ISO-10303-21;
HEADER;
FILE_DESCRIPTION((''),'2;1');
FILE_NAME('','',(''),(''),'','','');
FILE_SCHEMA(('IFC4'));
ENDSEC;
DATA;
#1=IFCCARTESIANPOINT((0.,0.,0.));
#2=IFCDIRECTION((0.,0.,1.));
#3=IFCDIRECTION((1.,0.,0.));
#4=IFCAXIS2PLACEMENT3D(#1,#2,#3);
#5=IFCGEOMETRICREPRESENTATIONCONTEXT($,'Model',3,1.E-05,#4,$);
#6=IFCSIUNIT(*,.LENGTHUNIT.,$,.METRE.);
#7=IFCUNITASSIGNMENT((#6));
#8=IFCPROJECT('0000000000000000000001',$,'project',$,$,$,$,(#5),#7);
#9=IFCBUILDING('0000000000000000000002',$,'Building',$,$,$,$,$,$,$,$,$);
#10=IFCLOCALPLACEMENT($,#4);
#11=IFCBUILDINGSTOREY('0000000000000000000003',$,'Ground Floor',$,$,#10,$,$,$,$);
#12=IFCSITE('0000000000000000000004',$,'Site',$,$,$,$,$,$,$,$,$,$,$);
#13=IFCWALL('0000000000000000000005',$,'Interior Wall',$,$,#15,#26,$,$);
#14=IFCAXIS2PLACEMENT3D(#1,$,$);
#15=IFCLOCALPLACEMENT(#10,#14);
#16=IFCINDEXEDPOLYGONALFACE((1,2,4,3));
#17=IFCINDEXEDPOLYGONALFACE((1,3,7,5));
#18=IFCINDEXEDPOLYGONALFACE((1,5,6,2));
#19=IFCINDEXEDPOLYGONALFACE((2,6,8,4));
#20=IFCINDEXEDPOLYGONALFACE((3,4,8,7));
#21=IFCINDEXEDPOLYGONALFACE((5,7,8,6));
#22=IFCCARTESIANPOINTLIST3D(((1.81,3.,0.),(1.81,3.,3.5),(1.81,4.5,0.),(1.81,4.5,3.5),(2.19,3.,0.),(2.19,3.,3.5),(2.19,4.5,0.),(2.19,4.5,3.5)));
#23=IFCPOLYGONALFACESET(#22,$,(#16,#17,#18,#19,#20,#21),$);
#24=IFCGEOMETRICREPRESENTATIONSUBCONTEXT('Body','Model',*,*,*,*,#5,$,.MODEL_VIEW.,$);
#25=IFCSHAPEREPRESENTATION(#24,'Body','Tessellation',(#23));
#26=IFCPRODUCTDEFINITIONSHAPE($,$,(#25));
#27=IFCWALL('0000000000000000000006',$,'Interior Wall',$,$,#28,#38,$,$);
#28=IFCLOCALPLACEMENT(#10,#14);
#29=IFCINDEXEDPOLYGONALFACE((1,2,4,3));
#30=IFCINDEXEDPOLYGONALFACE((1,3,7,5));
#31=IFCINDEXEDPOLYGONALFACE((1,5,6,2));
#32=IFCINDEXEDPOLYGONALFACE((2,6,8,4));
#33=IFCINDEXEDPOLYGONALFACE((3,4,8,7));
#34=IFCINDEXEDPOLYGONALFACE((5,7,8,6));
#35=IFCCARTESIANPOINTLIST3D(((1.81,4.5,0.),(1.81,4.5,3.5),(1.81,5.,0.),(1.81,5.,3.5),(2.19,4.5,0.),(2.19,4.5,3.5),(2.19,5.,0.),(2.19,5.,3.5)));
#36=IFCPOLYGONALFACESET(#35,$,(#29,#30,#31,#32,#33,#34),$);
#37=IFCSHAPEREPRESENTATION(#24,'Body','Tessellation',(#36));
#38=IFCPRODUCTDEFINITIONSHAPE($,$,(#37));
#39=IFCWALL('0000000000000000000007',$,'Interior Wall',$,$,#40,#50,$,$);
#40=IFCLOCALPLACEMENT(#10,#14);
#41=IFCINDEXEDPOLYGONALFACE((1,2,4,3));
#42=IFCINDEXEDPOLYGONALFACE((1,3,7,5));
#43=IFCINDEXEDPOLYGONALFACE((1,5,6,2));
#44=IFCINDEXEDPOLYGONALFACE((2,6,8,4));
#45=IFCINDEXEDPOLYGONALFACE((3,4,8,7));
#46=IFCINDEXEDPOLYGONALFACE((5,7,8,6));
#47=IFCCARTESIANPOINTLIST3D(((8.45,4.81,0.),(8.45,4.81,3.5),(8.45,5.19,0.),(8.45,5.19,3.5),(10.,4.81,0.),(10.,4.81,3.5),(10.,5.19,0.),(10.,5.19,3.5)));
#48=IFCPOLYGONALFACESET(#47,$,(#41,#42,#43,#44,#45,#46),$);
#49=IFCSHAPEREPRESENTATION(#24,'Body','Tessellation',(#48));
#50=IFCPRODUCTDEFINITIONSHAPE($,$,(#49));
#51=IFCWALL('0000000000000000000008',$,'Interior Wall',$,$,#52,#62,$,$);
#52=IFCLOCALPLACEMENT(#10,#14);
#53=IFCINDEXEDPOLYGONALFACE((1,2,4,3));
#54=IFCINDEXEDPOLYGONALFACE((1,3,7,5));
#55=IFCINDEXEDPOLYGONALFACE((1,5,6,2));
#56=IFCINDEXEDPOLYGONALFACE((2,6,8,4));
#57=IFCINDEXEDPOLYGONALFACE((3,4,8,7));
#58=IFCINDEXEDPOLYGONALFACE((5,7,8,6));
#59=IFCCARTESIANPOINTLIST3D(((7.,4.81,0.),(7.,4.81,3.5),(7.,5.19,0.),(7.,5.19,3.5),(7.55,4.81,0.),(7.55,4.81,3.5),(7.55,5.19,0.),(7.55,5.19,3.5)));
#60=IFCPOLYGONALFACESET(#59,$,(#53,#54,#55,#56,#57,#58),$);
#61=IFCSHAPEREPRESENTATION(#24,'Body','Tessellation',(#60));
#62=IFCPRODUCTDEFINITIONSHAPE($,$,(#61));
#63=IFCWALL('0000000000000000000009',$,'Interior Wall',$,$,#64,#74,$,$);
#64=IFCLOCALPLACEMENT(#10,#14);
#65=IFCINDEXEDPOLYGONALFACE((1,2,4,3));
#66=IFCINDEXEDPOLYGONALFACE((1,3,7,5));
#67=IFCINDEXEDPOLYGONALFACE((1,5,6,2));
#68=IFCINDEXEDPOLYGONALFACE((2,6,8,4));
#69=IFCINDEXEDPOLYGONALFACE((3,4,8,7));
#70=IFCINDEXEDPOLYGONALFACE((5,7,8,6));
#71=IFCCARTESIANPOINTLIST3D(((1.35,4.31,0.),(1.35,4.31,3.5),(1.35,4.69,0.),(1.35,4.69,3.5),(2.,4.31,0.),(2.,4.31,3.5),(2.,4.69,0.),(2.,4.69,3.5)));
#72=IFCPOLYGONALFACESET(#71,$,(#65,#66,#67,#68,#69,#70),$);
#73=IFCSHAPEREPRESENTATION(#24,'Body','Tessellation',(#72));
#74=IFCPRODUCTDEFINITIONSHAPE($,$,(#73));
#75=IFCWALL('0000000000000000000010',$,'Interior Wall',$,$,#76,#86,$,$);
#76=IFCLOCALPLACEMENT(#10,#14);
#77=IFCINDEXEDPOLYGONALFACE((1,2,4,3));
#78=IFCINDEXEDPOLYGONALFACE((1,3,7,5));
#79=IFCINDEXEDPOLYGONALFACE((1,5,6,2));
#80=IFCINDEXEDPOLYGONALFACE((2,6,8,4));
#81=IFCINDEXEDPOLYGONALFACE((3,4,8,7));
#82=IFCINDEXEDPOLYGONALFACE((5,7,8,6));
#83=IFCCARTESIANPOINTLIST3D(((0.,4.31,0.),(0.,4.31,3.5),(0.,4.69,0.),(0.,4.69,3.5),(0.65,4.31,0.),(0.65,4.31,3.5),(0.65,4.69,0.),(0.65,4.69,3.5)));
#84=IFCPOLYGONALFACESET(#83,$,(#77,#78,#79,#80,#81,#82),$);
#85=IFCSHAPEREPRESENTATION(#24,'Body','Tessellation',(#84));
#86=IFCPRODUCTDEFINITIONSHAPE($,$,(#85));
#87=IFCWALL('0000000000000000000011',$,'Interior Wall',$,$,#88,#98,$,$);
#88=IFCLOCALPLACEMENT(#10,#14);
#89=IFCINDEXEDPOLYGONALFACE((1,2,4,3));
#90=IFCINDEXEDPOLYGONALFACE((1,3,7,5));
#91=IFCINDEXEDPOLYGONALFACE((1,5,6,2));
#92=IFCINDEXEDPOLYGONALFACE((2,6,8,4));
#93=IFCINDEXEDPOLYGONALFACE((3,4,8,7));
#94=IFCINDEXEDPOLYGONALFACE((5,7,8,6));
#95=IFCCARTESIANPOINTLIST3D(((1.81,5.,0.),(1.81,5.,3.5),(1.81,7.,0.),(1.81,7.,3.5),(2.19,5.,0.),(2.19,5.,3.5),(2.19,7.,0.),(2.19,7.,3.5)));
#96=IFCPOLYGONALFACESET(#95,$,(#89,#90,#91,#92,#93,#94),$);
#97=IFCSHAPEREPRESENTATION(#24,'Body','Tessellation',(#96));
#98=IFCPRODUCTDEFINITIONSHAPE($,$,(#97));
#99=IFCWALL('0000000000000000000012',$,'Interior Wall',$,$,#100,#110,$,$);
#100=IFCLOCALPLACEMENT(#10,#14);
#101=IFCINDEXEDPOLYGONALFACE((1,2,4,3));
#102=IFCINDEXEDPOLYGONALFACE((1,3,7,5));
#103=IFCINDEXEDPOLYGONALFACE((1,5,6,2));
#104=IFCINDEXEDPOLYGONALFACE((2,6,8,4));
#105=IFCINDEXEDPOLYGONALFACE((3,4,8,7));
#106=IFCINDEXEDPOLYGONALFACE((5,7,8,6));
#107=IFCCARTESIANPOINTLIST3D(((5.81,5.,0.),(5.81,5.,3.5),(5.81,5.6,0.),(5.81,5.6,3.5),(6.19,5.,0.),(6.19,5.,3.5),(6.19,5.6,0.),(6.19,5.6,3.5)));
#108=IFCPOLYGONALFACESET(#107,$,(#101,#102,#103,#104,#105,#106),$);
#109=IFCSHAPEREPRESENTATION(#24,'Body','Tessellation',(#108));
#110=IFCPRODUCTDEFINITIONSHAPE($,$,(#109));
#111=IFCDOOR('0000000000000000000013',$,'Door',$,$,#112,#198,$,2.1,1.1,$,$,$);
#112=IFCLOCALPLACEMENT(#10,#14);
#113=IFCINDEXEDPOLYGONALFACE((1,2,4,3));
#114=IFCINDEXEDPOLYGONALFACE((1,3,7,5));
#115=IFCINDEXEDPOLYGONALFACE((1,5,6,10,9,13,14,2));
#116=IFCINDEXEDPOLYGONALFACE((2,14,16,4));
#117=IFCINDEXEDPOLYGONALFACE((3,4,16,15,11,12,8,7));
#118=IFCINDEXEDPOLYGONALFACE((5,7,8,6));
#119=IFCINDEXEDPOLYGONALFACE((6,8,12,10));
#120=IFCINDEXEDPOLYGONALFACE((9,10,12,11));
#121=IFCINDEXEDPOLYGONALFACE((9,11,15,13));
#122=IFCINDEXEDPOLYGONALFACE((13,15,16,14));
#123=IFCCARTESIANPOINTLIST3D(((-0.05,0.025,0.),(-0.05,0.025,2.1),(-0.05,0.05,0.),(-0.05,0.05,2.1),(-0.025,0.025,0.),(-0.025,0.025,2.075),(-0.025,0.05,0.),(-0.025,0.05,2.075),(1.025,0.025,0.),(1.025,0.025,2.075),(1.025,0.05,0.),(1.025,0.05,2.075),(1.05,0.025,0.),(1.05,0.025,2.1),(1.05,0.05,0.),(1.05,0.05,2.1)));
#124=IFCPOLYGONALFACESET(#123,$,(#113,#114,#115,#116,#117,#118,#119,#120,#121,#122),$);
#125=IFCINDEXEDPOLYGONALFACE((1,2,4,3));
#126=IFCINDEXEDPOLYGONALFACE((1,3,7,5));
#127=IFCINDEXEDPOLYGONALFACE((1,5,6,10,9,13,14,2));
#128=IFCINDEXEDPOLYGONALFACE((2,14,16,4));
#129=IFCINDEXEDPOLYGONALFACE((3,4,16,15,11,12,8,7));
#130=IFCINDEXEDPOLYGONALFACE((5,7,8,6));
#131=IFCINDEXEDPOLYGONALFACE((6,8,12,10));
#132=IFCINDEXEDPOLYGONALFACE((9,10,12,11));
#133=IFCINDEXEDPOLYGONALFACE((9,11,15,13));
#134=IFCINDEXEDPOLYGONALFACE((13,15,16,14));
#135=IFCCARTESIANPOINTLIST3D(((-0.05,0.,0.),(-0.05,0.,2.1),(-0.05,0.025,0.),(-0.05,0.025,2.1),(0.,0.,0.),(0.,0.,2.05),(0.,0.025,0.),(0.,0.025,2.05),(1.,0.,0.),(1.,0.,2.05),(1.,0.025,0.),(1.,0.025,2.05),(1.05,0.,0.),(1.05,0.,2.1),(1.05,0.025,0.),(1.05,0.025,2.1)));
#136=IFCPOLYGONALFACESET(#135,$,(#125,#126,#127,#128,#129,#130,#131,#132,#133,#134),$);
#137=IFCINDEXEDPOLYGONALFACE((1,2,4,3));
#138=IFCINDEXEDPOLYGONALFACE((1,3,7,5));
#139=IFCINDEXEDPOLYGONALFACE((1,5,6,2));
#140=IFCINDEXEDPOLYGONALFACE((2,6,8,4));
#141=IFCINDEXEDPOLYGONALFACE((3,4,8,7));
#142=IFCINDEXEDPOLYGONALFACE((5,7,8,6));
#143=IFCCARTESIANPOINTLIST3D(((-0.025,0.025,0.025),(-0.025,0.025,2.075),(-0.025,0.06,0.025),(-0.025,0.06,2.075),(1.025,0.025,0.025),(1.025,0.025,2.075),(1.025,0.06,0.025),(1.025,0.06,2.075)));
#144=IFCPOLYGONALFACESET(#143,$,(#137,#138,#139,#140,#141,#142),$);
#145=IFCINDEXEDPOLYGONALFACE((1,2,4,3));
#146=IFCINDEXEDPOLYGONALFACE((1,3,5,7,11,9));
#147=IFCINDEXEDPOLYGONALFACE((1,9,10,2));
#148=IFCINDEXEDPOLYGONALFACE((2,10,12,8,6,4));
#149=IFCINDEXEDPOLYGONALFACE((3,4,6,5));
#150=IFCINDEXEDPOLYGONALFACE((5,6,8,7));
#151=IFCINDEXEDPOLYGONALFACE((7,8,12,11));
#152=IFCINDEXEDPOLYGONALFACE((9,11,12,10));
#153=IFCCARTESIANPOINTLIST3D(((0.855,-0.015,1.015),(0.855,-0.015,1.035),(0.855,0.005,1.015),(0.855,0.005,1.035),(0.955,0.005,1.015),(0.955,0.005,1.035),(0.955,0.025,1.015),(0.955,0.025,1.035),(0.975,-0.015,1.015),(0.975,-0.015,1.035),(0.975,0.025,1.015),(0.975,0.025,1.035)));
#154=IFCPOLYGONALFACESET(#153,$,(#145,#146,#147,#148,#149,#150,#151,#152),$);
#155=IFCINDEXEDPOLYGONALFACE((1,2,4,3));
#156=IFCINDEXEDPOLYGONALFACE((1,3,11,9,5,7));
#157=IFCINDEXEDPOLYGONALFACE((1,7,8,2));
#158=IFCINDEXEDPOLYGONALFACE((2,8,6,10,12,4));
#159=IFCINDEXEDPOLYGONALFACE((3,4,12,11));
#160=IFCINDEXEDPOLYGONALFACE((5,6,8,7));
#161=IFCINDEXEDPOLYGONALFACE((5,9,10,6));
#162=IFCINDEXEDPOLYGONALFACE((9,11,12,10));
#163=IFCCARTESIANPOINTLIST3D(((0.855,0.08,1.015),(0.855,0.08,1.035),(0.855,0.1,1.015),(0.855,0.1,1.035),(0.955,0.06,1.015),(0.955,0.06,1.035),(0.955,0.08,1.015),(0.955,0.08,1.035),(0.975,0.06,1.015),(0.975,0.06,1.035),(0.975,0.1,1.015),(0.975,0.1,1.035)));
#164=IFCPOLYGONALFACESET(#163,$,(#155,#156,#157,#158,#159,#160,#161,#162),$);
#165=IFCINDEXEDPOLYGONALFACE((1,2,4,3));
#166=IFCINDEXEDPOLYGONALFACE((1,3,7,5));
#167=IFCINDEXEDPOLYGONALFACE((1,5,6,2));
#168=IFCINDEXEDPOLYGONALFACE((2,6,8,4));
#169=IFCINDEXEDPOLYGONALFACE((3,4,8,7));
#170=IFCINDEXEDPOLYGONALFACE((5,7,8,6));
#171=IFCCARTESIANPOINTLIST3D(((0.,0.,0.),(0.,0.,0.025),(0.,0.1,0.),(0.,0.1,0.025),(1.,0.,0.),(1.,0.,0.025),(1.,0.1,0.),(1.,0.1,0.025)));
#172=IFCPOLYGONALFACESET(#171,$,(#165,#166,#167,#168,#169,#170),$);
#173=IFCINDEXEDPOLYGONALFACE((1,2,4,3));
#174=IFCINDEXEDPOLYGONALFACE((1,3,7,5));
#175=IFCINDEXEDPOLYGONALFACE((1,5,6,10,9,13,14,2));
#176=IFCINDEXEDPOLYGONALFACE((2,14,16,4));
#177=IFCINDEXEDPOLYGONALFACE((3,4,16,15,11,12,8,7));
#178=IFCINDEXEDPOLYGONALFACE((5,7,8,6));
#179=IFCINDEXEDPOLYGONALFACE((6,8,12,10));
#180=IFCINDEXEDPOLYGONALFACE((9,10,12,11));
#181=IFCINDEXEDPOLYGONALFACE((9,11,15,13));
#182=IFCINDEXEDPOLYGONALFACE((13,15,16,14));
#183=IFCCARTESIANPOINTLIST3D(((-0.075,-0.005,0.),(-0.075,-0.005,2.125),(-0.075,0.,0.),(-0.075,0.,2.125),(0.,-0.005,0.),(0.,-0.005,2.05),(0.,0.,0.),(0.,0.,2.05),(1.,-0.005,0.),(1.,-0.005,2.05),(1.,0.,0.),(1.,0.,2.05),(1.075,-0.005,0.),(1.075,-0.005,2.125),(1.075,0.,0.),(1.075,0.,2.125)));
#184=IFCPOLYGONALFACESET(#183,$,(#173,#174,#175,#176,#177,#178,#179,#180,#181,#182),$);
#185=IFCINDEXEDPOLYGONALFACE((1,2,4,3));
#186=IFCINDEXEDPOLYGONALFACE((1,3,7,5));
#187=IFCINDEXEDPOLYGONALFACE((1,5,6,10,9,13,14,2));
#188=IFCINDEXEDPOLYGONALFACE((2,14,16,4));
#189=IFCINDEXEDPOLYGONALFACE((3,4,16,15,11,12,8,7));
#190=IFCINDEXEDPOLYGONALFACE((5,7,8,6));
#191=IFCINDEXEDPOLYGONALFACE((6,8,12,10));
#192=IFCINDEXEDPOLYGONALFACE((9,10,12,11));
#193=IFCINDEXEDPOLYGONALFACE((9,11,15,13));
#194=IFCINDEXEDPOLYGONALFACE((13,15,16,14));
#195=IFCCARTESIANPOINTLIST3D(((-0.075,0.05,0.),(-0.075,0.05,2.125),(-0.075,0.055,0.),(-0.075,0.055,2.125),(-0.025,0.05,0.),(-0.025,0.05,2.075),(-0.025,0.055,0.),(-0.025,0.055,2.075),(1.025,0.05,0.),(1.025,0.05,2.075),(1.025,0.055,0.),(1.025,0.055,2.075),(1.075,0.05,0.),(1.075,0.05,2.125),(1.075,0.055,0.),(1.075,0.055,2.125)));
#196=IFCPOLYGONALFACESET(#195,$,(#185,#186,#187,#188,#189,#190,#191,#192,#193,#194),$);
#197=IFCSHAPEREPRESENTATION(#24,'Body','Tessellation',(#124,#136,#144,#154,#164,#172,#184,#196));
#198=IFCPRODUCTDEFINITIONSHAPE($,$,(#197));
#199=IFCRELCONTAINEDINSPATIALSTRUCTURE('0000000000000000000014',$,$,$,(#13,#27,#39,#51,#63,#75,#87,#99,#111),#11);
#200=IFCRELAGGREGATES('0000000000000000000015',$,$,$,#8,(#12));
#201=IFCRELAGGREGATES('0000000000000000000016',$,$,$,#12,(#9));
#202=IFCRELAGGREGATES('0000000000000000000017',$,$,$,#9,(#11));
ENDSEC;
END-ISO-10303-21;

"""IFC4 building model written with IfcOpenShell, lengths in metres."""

from ifc_helpers import new_model, si_unit, frame, origin_with_axes, place, context, subcontext, project, spatial, line, indexed_curve, outline, extrude, element, save


model = new_model("IFC4")

# Units and contexts
model_context = context("Model", 3, precision=1e-05, world=origin_with_axes())
body_context = subcontext(model_context, "Body", "Model", "MODEL_VIEW")
ifc_project = project(units=[si_unit("LENGTHUNIT", "METRE")], contexts=[model_context])

# Site, building, storey
site = spatial("IfcSite", under=ifc_project, Name="Site")
building = spatial("IfcBuilding", under=site, Name="Building")
storey_placement = place(None, origin_with_axes())
storey = spatial("IfcBuildingStorey", under=building, at=storey_placement, Name="Ground Floor")

# Walls
wall_1_placement = place(storey_placement, frame((2.0, 4.5, 0.0), z_axis=(0.0, 0.0, 1.0), x_axis=(0.0, -1.0, 0.0)))
element("IfcWall", 1, at=wall_1_placement, inside=storey, Name="Interior Wall", context=body_context, shape_type="SweptSolid", body=[
    extrude(outline(indexed_curve([(0.0, 0.0), (0.0, 0.38), (1.5, 0.38), (1.5, 0.0), (0.0, 0.0)], self_intersect=False)), frame((0.0, -0.19, 0.0), z_axis=(0.0, 0.0, 1.0), x_axis=(1.0, 0.0, 0.0)), (0.0, 0.0, 1.0), 3.5),
])
wall_2_placement = place(storey_placement, frame((2.0, 5.0, 0.0), z_axis=(0.0, 0.0, 1.0), x_axis=(0.0, -1.0, 0.0)))
element("IfcWall", 2, at=wall_2_placement, inside=storey, Name="Interior Wall", context=body_context, shape_type="SweptSolid", body=[
    extrude(outline(indexed_curve([(0.0, 0.0), (0.0, 0.38), (0.5, 0.38), (0.5, 0.0), (0.0, 0.0)], self_intersect=False)), frame((0.0, -0.19, 0.0), z_axis=(0.0, 0.0, 1.0), x_axis=(1.0, 0.0, 0.0)), (0.0, 0.0, 1.0), 3.5),
])
wall_3_placement = place(storey_placement, frame((10.0, 5.0, 0.0), z_axis=(0.0, 0.0, 1.0), x_axis=(-1.0, 0.0, 0.0)))
element("IfcWall", 3, at=wall_3_placement, inside=storey, Name="Interior Wall", context=body_context, shape_type="SweptSolid", body=[
    extrude(outline(indexed_curve([(0.0, 0.0), (0.0, 0.38), (1.55, 0.38), (1.55, 0.0), (0.0, 0.0)], self_intersect=False)), frame((0.0, -0.19, 0.0), z_axis=(0.0, 0.0, 1.0), x_axis=(1.0, 0.0, 0.0)), (0.0, 0.0, 1.0), 3.5),
])
wall_4_placement = place(storey_placement, frame((7.55, 5.0, 0.0), z_axis=(0.0, 0.0, 1.0), x_axis=(-1.0, 0.0, 0.0)))
element("IfcWall", 4, at=wall_4_placement, inside=storey, Name="Interior Wall", context=body_context, shape_type="SweptSolid", body=[
    extrude(outline(indexed_curve([(0.0, 0.0), (0.0, 0.38), (0.55, 0.38), (0.55, 0.0), (0.0, 0.0)], self_intersect=False)), frame((0.0, -0.19, 0.0), z_axis=(0.0, 0.0, 1.0), x_axis=(1.0, 0.0, 0.0)), (0.0, 0.0, 1.0), 3.5),
])
for number, where, z_axis, x_axis, name in (
    (5, (2.0, 4.5, 0.0), (0.0, 0.0, 1.0), (-1.0, 0.0, 0.0), "Interior Wall"),
    (6, (0.65, 4.5, 0.0), (0.0, 0.0, 1.0), (-1.0, 0.0, 0.0), "Interior Wall"),
):
    element("IfcWall", number, at=place(storey_placement, frame(where, z_axis=z_axis, x_axis=x_axis)), inside=storey, Name=name, context=body_context, shape_type="SweptSolid", body=[
        extrude(outline(indexed_curve([(0.0, 0.0), (0.0, 0.38), (0.65, 0.38), (0.65, 0.0), (0.0, 0.0)], self_intersect=False)), frame((0.0, -0.19, 0.0), z_axis=(0.0, 0.0, 1.0), x_axis=(1.0, 0.0, 0.0)), (0.0, 0.0, 1.0), 3.5),
    ])
wall_5_placement = place(storey_placement, frame((2.0, 5.0, 0.0), z_axis=(0.0, 0.0, 1.0), x_axis=(0.0, 1.0, 0.0)))
element("IfcWall", 7, at=wall_5_placement, inside=storey, Name="Interior Wall", context=body_context, shape_type="SweptSolid", body=[
    extrude(outline(indexed_curve([(0.0, 0.0), (0.0, 0.38), (2.0, 0.38), (2.0, 0.0), (0.0, 0.0)], self_intersect=False)), frame((0.0, -0.19, 0.0), z_axis=(0.0, 0.0, 1.0), x_axis=(1.0, 0.0, 0.0)), (0.0, 0.0, 1.0), 3.5),
])
wall_6_placement = place(storey_placement, frame((6.0, 5.0, 0.0), z_axis=(0.0, 0.0, 1.0), x_axis=(0.0, 1.0, 0.0)))
element("IfcWall", 8, at=wall_6_placement, inside=storey, Name="Interior Wall", context=body_context, shape_type="SweptSolid", body=[
    extrude(outline(indexed_curve([(0.0, 0.0), (0.0, 0.38), (0.6, 0.38), (0.6, 0.0), (0.0, 0.0)], self_intersect=False)), frame((0.0, -0.19, 0.0), z_axis=(0.0, 0.0, 1.0), x_axis=(1.0, 0.0, 0.0)), (0.0, 0.0, 1.0), 3.5),
])

# Door
door_1_placement = place(storey_placement, frame((-0.05, 0.0, 0.0), z_axis=(0.0, 0.0, 1.0), x_axis=(1.0, 0.0, 0.0)))
element("IfcDoor", 9, at=door_1_placement, inside=storey, Name="Door", OverallHeight=2.1, OverallWidth=1.1, context=body_context, shape_type="SweptSolid", body=[
    extrude(outline(indexed_curve([(0.0, 0.0), (0.0, 2.1), (1.1, 2.1), (1.1, 0.0), (1.075, 0.0), (1.075, 2.075), (0.025, 2.075), (0.025, 0.0)], segments=[line(1, 2, 3, 4, 5, 6, 7, 8, 1)])), frame((0.0, 0.025, 0.0), z_axis=(0.0, -1.0, 0.0), x_axis=(1.0, 0.0, 0.0)), (0.0, 0.0, -1.0), 0.025),
    extrude(outline(indexed_curve([(0.0, 0.0), (0.0, 2.1), (1.1, 2.1), (1.1, 0.0), (1.05, 0.0), (1.05, 2.05), (0.05, 2.05), (0.05, 0.0)], segments=[line(1, 2, 3, 4, 5, 6, 7, 8, 1)])), frame((0.0, 0.0, 0.0), z_axis=(0.0, -1.0, 0.0), x_axis=(1.0, 0.0, 0.0)), (0.0, 0.0, -1.0), 0.025),
    extrude(outline(indexed_curve([(0.0, 0.0), (1.05, 0.0), (1.05, 0.035), (0.0, 0.035)], segments=[line(1, 2, 3, 4, 1)])), frame((0.025, 0.025, 0.025), z_axis=(0.0, 0.0, 1.0), x_axis=(1.0, 0.0, 0.0)), (0.0, 0.0, 1.0), 2.05),
    extrude(outline(indexed_curve([(0.0, 0.0), (0.0, -0.04), (-0.12, -0.04), (-0.12, -0.02), (-0.02, -0.02), (-0.02, 0.0)], segments=[line(1, 2, 3, 4, 5, 6, 1)])), frame((1.025, 0.025, 1.015), z_axis=(0.0, 0.0, 1.0), x_axis=(1.0, 0.0, 0.0)), (0.0, 0.0, 1.0), 0.02),
    extrude(outline(indexed_curve([(0.0, 0.0), (0.0, 0.04), (-0.12, 0.04), (-0.12, 0.02), (-0.02, 0.02), (-0.02, 0.0)], segments=[line(1, 2, 3, 4, 5, 6, 1)])), frame((1.025, 0.06, 1.015), z_axis=(0.0, 0.0, 1.0), x_axis=(1.0, 0.0, 0.0)), (0.0, 0.0, 1.0), 0.02),
    extrude(outline(indexed_curve([(0.0, 0.0), (1.0, 0.0), (1.0, 0.1), (0.0, 0.1)], segments=[line(1, 2, 3, 4, 1)])), frame((0.05, 0.0, 0.0), z_axis=(0.0, 0.0, 1.0), x_axis=(1.0, 0.0, 0.0)), (0.0, 0.0, 1.0), 0.025),
    extrude(outline(indexed_curve([(0.0, 0.0), (0.0, 2.125), (1.15, 2.125), (1.15, 0.0), (1.075, 0.0), (1.075, 2.05), (0.075, 2.05), (0.075, 0.0)], segments=[line(1, 2, 3, 4, 5, 6, 7, 8, 1)])), frame((-0.025, -0.005, 0.0), z_axis=(0.0, -1.0, 0.0), x_axis=(1.0, 0.0, 0.0)), (0.0, 0.0, -1.0), 0.005),
    extrude(outline(indexed_curve([(0.0, 0.0), (0.0, 2.125), (1.15, 2.125), (1.15, 0.0), (1.1, 0.0), (1.1, 2.075), (0.05, 2.075), (0.05, 0.0)], segments=[line(1, 2, 3, 4, 5, 6, 7, 8, 1)])), frame((-0.025, 0.05, 0.0), z_axis=(0.0, -1.0, 0.0), x_axis=(1.0, 0.0, 0.0)), (0.0, 0.0, -1.0), 0.005),
])

save(model, "model.ifc")
